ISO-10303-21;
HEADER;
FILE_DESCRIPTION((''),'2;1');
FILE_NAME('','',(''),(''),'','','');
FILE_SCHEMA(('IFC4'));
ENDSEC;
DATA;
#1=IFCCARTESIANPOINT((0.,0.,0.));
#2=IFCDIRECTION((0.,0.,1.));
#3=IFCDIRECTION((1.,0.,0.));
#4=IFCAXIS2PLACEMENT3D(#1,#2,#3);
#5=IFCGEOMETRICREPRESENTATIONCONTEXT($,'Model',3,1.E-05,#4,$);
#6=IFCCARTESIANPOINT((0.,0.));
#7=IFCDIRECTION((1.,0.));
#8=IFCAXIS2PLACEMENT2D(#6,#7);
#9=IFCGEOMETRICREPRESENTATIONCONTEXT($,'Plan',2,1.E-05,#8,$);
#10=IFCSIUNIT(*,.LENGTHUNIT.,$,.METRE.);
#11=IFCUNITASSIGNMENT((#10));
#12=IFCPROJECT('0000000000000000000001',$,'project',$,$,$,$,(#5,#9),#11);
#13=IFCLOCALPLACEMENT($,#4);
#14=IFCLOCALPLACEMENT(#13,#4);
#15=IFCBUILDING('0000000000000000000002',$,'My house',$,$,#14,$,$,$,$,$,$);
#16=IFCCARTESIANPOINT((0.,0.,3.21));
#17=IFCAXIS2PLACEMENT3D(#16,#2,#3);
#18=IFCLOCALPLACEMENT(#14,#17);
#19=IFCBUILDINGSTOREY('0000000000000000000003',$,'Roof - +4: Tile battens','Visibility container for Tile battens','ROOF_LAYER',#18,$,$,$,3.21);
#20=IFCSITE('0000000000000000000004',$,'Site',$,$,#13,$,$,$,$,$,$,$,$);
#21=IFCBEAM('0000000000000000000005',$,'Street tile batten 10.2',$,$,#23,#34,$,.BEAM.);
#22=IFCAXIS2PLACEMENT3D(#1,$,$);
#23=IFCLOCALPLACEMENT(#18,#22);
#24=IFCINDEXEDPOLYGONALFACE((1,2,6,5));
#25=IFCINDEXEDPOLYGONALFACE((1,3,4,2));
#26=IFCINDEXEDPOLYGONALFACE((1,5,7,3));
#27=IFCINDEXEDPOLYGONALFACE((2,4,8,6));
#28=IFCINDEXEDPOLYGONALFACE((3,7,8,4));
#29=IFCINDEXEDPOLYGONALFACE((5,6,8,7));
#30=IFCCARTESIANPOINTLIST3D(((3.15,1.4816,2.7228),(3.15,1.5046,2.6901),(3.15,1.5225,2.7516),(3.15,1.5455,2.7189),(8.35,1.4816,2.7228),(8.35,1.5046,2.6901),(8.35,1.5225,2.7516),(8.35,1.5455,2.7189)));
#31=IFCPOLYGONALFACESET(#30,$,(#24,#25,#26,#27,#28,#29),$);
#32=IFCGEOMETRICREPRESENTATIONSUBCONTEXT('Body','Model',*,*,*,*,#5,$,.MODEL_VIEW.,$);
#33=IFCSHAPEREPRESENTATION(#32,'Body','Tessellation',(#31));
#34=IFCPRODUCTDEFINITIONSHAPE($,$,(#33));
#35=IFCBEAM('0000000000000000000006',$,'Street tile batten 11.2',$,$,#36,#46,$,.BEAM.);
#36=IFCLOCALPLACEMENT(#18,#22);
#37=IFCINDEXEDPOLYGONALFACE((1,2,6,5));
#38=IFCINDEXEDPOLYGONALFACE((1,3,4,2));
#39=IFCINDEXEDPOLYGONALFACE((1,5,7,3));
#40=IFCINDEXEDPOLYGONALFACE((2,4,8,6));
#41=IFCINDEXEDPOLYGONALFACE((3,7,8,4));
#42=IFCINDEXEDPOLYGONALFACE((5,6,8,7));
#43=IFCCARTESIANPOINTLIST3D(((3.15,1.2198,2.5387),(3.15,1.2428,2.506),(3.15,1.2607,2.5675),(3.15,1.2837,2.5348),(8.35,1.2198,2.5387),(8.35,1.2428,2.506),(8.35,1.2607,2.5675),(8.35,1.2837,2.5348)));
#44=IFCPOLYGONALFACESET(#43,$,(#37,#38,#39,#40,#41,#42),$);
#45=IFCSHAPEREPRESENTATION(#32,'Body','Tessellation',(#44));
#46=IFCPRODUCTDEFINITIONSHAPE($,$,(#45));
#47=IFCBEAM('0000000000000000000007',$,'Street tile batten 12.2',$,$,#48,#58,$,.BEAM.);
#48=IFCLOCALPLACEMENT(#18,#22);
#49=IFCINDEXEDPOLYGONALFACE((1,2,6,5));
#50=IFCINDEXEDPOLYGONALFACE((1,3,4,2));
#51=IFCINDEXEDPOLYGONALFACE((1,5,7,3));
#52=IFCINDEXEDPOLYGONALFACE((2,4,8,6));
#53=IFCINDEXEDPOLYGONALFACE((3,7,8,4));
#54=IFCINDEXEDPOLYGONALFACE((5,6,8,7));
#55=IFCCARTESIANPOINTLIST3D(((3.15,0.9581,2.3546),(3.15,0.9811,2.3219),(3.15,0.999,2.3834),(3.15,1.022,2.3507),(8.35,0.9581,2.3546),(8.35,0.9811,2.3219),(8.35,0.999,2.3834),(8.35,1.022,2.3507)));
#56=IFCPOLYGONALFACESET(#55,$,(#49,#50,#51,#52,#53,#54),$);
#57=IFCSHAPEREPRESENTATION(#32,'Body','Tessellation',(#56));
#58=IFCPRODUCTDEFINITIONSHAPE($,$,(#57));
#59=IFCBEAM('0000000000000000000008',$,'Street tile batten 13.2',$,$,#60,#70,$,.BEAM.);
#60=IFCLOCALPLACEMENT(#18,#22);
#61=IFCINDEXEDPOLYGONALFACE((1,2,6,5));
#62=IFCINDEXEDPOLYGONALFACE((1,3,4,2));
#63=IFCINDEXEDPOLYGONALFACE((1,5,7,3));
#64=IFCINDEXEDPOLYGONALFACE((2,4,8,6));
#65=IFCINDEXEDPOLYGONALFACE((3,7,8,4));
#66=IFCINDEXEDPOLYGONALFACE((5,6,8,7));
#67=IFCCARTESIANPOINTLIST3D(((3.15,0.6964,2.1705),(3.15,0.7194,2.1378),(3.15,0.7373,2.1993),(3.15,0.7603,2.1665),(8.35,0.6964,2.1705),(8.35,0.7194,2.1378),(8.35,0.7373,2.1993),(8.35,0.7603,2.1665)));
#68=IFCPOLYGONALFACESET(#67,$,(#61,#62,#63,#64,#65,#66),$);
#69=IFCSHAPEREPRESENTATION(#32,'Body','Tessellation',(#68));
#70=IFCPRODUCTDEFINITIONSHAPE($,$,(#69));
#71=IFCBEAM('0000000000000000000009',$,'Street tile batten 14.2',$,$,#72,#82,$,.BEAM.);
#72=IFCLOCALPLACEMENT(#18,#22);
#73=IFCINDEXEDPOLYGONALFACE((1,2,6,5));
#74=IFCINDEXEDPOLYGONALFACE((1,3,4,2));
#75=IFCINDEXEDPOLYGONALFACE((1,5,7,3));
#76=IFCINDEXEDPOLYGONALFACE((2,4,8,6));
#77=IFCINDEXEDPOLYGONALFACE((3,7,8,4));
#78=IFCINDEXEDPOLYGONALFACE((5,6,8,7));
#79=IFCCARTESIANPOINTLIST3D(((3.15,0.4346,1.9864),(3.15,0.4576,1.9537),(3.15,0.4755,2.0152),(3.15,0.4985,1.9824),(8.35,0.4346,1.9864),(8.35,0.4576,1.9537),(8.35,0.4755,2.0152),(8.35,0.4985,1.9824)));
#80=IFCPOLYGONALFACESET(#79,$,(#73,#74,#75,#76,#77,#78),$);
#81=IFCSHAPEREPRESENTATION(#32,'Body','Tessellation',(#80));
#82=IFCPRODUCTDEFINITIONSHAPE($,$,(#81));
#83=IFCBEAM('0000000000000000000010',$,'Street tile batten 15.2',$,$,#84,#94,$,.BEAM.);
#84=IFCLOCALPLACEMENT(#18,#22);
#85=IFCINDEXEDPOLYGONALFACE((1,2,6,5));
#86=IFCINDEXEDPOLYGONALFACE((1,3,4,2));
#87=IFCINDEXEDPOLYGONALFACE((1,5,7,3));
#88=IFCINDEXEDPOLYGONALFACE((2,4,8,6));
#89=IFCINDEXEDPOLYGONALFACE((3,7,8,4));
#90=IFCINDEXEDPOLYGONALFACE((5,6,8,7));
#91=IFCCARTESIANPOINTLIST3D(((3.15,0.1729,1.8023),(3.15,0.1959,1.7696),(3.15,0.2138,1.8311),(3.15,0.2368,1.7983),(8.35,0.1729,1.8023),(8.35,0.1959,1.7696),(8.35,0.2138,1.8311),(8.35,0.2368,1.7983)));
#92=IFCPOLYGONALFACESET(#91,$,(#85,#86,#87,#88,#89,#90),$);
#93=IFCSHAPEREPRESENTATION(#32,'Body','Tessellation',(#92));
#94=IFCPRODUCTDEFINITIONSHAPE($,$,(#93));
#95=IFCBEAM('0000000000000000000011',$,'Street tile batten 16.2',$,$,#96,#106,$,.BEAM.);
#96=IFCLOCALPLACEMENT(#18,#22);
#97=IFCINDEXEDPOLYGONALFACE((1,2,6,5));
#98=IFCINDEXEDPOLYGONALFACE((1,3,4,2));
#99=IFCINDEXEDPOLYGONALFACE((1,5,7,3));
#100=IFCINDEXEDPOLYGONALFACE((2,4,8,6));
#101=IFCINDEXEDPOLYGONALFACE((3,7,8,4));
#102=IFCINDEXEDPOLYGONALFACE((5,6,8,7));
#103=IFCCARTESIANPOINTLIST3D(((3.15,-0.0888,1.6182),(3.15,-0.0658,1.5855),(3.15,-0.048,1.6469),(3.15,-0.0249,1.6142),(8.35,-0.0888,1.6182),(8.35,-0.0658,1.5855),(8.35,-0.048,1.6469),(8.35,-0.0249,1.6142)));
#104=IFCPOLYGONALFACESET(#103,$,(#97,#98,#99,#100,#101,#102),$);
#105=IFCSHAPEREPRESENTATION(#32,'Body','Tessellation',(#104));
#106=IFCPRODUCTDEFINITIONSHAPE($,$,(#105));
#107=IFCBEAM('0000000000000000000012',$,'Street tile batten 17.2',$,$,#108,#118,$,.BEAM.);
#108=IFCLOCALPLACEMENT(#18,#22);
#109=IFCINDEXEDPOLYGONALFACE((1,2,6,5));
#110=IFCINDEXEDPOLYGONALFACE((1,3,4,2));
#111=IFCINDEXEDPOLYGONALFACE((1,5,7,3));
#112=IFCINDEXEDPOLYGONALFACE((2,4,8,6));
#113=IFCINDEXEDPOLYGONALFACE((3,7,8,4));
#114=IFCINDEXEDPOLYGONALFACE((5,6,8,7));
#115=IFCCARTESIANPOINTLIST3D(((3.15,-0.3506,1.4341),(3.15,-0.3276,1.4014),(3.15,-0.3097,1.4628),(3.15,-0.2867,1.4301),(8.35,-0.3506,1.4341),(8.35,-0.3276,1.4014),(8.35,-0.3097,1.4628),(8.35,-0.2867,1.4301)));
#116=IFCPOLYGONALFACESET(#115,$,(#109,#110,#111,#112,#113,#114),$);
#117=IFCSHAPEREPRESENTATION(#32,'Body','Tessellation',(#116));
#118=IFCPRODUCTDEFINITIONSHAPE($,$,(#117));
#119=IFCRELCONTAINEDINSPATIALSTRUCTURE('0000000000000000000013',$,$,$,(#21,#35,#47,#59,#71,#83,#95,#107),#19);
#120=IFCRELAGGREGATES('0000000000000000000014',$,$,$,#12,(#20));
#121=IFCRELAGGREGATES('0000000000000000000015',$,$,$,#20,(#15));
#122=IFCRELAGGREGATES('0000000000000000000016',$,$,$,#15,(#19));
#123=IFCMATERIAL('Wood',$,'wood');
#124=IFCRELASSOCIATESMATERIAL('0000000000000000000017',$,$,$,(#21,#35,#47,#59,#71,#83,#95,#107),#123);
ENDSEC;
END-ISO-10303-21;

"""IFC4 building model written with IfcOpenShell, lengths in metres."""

from ifc_helpers import new_model, si_unit, frame, origin_with_axes, origin_2d_with_axis, place, context, subcontext, project, spatial, rectangle, extrude, clip, halfspace, material, element, save


model = new_model("IFC4")

# Units and contexts
model_context = context("Model", 3, precision=1e-05, world=origin_with_axes())
plan_context = context("Plan", 2, precision=1e-05, world=origin_2d_with_axis())
body_context = subcontext(model_context, "Body", "Model", "MODEL_VIEW")
ifc_project = project(units=[si_unit("LENGTHUNIT", "METRE")], contexts=[model_context, plan_context])

# Site, building, storey
site_placement = place(None, origin_with_axes())
site = spatial("IfcSite", under=ifc_project, at=site_placement, Name="Site")
building_placement = place(site_placement, origin_with_axes())
building = spatial("IfcBuilding", under=site, at=building_placement, Name="My house")
storey_placement = place(building_placement, frame((0.0, 0.0, 3.21), z_axis=(0.0, 0.0, 1.0), x_axis=(1.0, 0.0, 0.0)))
storey = spatial("IfcBuildingStorey", under=building, at=storey_placement, Name="Roof - +4: Tile battens", Description="Visibility container for Tile battens", ObjectType="ROOF_LAYER", Elevation=3.21)

# Beams
ifc_material = material(Name="Wood", Category="wood")
beam_1_placement = place(storey_placement, frame((3.15, 1.5135, 2.7208), z_axis=(0.0, -0.575329, 0.817922), x_axis=(1.0, 0.0, 0.0)))
element("IfcBeam", 1, at=beam_1_placement, inside=storey, material=ifc_material, Name="Street tile batten 10.2", PredefinedType="BEAM", context=body_context, shape_type="Clipping", body=[
    clip(clip(extrude(rectangle(XDim=0.05, YDim=0.04), frame((0.0, 0.0, 0.0), z_axis=(1.0, 0.0, 0.0), x_axis=(0.0, 1.0, 0.0)), (0.0, 0.0, 1.0), 5.2), halfspace(frame((-3.15, -1.3784, -6.2815), z_axis=(0.0, 0.817922, -0.575329), x_axis=(1.0, 0.0, 0.0)), False)), halfspace(frame((-3.15, -4.9773, -3.7501), z_axis=(0.0, -0.817922, 0.575329), x_axis=(-1.0, 0.0, 0.0)), False)),
])
beam_2_placement = place(storey_placement, frame((3.15, 1.2518, 2.5367), z_axis=(0.0, -0.575329, 0.817922), x_axis=(1.0, 0.0, 0.0)))
element("IfcBeam", 2, at=beam_2_placement, inside=storey, material=ifc_material, Name="Street tile batten 11.2", PredefinedType="BEAM", context=body_context, shape_type="Clipping", body=[
    clip(clip(extrude(rectangle(XDim=0.05, YDim=0.04), frame((0.0, 0.0, 0.0), z_axis=(1.0, 0.0, 0.0), x_axis=(0.0, 1.0, 0.0)), (0.0, 0.0, 1.0), 5.2), halfspace(frame((-3.15, -1.0584, -6.2815), z_axis=(0.0, 0.817922, -0.575329), x_axis=(1.0, 0.0, 0.0)), False)), halfspace(frame((-3.15, -4.6573, -3.7501), z_axis=(0.0, -0.817922, 0.575329), x_axis=(-1.0, 0.0, 0.0)), False)),
])
beam_3_placement = place(storey_placement, frame((3.15, 0.99, 2.3526), z_axis=(0.0, -0.575329, 0.817922), x_axis=(1.0, 0.0, 0.0)))
element("IfcBeam", 3, at=beam_3_placement, inside=storey, material=ifc_material, Name="Street tile batten 12.2", PredefinedType="BEAM", context=body_context, shape_type="Clipping", body=[
    clip(clip(extrude(rectangle(XDim=0.05, YDim=0.04), frame((0.0, 0.0, 0.0), z_axis=(1.0, 0.0, 0.0), x_axis=(0.0, 1.0, 0.0)), (0.0, 0.0, 1.0), 5.2), halfspace(frame((-3.15, -0.7384, -6.2815), z_axis=(0.0, 0.817922, -0.575329), x_axis=(1.0, 0.0, 0.0)), False)), halfspace(frame((-3.15, -4.3373, -3.7501), z_axis=(0.0, -0.817922, 0.575329), x_axis=(-1.0, 0.0, 0.0)), False)),
])
beam_4_placement = place(storey_placement, frame((3.15, 0.7283, 2.1685), z_axis=(0.0, -0.575329, 0.817922), x_axis=(1.0, 0.0, 0.0)))
element("IfcBeam", 4, at=beam_4_placement, inside=storey, material=ifc_material, Name="Street tile batten 13.2", PredefinedType="BEAM", context=body_context, shape_type="Clipping", body=[
    clip(clip(extrude(rectangle(XDim=0.05, YDim=0.04), frame((0.0, 0.0, 0.0), z_axis=(1.0, 0.0, 0.0), x_axis=(0.0, 1.0, 0.0)), (0.0, 0.0, 1.0), 5.2), halfspace(frame((-3.15, -0.4184, -6.2815), z_axis=(0.0, 0.817922, -0.575329), x_axis=(1.0, 0.0, 0.0)), False)), halfspace(frame((-3.15, -4.0173, -3.7501), z_axis=(0.0, -0.817922, 0.575329), x_axis=(-1.0, 0.0, 0.0)), False)),
])
beam_5_placement = place(storey_placement, frame((3.15, 0.4666, 1.9844), z_axis=(0.0, -0.575329, 0.817922), x_axis=(1.0, 0.0, 0.0)))
element("IfcBeam", 5, at=beam_5_placement, inside=storey, material=ifc_material, Name="Street tile batten 14.2", PredefinedType="BEAM", context=body_context, shape_type="Clipping", body=[
    clip(clip(extrude(rectangle(XDim=0.05, YDim=0.04), frame((0.0, 0.0, 0.0), z_axis=(1.0, 0.0, 0.0), x_axis=(0.0, 1.0, 0.0)), (0.0, 0.0, 1.0), 5.2), halfspace(frame((-3.15, -0.0984, -6.2815), z_axis=(0.0, 0.817922, -0.575329), x_axis=(1.0, 0.0, 0.0)), False)), halfspace(frame((-3.15, -3.6973, -3.7501), z_axis=(0.0, -0.817922, 0.575329), x_axis=(-1.0, 0.0, 0.0)), False)),
])
beam_6_placement = place(storey_placement, frame((3.15, 0.2048, 1.8003), z_axis=(0.0, -0.575329, 0.817922), x_axis=(1.0, 0.0, 0.0)))
element("IfcBeam", 6, at=beam_6_placement, inside=storey, material=ifc_material, Name="Street tile batten 15.2", PredefinedType="BEAM", context=body_context, shape_type="Clipping", body=[
    clip(clip(extrude(rectangle(XDim=0.05, YDim=0.04), frame((0.0, 0.0, 0.0), z_axis=(1.0, 0.0, 0.0), x_axis=(0.0, 1.0, 0.0)), (0.0, 0.0, 1.0), 5.2), halfspace(frame((-3.15, 0.2216, -6.2815), z_axis=(0.0, 0.817922, -0.575329), x_axis=(1.0, 0.0, 0.0)), False)), halfspace(frame((-3.15, -3.3773, -3.7501), z_axis=(0.0, -0.817922, 0.575329), x_axis=(-1.0, 0.0, 0.0)), False)),
])
beam_7_placement = place(storey_placement, frame((3.15, -0.0569, 1.6162), z_axis=(0.0, -0.575329, 0.817922), x_axis=(1.0, 0.0, 0.0)))
element("IfcBeam", 7, at=beam_7_placement, inside=storey, material=ifc_material, Name="Street tile batten 16.2", PredefinedType="BEAM", context=body_context, shape_type="Clipping", body=[
    clip(clip(extrude(rectangle(XDim=0.05, YDim=0.04), frame((0.0, 0.0, 0.0), z_axis=(1.0, 0.0, 0.0), x_axis=(0.0, 1.0, 0.0)), (0.0, 0.0, 1.0), 5.2), halfspace(frame((-3.15, 0.5416, -6.2815), z_axis=(0.0, 0.817922, -0.575329), x_axis=(1.0, 0.0, 0.0)), False)), halfspace(frame((-3.15, -3.0573, -3.7501), z_axis=(0.0, -0.817922, 0.575329), x_axis=(-1.0, 0.0, 0.0)), False)),
])
beam_8_placement = place(storey_placement, frame((3.15, -0.3186, 1.4321), z_axis=(0.0, -0.575329, 0.817922), x_axis=(1.0, 0.0, 0.0)))
element("IfcBeam", 8, at=beam_8_placement, inside=storey, material=ifc_material, Name="Street tile batten 17.2", PredefinedType="BEAM", context=body_context, shape_type="Clipping", body=[
    clip(clip(extrude(rectangle(XDim=0.05, YDim=0.04), frame((0.0, 0.0, 0.0), z_axis=(1.0, 0.0, 0.0), x_axis=(0.0, 1.0, 0.0)), (0.0, 0.0, 1.0), 5.2), halfspace(frame((-3.15, 0.8616, -6.2815), z_axis=(0.0, 0.817922, -0.575329), x_axis=(1.0, 0.0, 0.0)), False)), halfspace(frame((-3.15, -2.7373, -3.7501), z_axis=(0.0, -0.817922, 0.575329), x_axis=(-1.0, 0.0, 0.0)), False)),
])

save(model, "model.ifc")
